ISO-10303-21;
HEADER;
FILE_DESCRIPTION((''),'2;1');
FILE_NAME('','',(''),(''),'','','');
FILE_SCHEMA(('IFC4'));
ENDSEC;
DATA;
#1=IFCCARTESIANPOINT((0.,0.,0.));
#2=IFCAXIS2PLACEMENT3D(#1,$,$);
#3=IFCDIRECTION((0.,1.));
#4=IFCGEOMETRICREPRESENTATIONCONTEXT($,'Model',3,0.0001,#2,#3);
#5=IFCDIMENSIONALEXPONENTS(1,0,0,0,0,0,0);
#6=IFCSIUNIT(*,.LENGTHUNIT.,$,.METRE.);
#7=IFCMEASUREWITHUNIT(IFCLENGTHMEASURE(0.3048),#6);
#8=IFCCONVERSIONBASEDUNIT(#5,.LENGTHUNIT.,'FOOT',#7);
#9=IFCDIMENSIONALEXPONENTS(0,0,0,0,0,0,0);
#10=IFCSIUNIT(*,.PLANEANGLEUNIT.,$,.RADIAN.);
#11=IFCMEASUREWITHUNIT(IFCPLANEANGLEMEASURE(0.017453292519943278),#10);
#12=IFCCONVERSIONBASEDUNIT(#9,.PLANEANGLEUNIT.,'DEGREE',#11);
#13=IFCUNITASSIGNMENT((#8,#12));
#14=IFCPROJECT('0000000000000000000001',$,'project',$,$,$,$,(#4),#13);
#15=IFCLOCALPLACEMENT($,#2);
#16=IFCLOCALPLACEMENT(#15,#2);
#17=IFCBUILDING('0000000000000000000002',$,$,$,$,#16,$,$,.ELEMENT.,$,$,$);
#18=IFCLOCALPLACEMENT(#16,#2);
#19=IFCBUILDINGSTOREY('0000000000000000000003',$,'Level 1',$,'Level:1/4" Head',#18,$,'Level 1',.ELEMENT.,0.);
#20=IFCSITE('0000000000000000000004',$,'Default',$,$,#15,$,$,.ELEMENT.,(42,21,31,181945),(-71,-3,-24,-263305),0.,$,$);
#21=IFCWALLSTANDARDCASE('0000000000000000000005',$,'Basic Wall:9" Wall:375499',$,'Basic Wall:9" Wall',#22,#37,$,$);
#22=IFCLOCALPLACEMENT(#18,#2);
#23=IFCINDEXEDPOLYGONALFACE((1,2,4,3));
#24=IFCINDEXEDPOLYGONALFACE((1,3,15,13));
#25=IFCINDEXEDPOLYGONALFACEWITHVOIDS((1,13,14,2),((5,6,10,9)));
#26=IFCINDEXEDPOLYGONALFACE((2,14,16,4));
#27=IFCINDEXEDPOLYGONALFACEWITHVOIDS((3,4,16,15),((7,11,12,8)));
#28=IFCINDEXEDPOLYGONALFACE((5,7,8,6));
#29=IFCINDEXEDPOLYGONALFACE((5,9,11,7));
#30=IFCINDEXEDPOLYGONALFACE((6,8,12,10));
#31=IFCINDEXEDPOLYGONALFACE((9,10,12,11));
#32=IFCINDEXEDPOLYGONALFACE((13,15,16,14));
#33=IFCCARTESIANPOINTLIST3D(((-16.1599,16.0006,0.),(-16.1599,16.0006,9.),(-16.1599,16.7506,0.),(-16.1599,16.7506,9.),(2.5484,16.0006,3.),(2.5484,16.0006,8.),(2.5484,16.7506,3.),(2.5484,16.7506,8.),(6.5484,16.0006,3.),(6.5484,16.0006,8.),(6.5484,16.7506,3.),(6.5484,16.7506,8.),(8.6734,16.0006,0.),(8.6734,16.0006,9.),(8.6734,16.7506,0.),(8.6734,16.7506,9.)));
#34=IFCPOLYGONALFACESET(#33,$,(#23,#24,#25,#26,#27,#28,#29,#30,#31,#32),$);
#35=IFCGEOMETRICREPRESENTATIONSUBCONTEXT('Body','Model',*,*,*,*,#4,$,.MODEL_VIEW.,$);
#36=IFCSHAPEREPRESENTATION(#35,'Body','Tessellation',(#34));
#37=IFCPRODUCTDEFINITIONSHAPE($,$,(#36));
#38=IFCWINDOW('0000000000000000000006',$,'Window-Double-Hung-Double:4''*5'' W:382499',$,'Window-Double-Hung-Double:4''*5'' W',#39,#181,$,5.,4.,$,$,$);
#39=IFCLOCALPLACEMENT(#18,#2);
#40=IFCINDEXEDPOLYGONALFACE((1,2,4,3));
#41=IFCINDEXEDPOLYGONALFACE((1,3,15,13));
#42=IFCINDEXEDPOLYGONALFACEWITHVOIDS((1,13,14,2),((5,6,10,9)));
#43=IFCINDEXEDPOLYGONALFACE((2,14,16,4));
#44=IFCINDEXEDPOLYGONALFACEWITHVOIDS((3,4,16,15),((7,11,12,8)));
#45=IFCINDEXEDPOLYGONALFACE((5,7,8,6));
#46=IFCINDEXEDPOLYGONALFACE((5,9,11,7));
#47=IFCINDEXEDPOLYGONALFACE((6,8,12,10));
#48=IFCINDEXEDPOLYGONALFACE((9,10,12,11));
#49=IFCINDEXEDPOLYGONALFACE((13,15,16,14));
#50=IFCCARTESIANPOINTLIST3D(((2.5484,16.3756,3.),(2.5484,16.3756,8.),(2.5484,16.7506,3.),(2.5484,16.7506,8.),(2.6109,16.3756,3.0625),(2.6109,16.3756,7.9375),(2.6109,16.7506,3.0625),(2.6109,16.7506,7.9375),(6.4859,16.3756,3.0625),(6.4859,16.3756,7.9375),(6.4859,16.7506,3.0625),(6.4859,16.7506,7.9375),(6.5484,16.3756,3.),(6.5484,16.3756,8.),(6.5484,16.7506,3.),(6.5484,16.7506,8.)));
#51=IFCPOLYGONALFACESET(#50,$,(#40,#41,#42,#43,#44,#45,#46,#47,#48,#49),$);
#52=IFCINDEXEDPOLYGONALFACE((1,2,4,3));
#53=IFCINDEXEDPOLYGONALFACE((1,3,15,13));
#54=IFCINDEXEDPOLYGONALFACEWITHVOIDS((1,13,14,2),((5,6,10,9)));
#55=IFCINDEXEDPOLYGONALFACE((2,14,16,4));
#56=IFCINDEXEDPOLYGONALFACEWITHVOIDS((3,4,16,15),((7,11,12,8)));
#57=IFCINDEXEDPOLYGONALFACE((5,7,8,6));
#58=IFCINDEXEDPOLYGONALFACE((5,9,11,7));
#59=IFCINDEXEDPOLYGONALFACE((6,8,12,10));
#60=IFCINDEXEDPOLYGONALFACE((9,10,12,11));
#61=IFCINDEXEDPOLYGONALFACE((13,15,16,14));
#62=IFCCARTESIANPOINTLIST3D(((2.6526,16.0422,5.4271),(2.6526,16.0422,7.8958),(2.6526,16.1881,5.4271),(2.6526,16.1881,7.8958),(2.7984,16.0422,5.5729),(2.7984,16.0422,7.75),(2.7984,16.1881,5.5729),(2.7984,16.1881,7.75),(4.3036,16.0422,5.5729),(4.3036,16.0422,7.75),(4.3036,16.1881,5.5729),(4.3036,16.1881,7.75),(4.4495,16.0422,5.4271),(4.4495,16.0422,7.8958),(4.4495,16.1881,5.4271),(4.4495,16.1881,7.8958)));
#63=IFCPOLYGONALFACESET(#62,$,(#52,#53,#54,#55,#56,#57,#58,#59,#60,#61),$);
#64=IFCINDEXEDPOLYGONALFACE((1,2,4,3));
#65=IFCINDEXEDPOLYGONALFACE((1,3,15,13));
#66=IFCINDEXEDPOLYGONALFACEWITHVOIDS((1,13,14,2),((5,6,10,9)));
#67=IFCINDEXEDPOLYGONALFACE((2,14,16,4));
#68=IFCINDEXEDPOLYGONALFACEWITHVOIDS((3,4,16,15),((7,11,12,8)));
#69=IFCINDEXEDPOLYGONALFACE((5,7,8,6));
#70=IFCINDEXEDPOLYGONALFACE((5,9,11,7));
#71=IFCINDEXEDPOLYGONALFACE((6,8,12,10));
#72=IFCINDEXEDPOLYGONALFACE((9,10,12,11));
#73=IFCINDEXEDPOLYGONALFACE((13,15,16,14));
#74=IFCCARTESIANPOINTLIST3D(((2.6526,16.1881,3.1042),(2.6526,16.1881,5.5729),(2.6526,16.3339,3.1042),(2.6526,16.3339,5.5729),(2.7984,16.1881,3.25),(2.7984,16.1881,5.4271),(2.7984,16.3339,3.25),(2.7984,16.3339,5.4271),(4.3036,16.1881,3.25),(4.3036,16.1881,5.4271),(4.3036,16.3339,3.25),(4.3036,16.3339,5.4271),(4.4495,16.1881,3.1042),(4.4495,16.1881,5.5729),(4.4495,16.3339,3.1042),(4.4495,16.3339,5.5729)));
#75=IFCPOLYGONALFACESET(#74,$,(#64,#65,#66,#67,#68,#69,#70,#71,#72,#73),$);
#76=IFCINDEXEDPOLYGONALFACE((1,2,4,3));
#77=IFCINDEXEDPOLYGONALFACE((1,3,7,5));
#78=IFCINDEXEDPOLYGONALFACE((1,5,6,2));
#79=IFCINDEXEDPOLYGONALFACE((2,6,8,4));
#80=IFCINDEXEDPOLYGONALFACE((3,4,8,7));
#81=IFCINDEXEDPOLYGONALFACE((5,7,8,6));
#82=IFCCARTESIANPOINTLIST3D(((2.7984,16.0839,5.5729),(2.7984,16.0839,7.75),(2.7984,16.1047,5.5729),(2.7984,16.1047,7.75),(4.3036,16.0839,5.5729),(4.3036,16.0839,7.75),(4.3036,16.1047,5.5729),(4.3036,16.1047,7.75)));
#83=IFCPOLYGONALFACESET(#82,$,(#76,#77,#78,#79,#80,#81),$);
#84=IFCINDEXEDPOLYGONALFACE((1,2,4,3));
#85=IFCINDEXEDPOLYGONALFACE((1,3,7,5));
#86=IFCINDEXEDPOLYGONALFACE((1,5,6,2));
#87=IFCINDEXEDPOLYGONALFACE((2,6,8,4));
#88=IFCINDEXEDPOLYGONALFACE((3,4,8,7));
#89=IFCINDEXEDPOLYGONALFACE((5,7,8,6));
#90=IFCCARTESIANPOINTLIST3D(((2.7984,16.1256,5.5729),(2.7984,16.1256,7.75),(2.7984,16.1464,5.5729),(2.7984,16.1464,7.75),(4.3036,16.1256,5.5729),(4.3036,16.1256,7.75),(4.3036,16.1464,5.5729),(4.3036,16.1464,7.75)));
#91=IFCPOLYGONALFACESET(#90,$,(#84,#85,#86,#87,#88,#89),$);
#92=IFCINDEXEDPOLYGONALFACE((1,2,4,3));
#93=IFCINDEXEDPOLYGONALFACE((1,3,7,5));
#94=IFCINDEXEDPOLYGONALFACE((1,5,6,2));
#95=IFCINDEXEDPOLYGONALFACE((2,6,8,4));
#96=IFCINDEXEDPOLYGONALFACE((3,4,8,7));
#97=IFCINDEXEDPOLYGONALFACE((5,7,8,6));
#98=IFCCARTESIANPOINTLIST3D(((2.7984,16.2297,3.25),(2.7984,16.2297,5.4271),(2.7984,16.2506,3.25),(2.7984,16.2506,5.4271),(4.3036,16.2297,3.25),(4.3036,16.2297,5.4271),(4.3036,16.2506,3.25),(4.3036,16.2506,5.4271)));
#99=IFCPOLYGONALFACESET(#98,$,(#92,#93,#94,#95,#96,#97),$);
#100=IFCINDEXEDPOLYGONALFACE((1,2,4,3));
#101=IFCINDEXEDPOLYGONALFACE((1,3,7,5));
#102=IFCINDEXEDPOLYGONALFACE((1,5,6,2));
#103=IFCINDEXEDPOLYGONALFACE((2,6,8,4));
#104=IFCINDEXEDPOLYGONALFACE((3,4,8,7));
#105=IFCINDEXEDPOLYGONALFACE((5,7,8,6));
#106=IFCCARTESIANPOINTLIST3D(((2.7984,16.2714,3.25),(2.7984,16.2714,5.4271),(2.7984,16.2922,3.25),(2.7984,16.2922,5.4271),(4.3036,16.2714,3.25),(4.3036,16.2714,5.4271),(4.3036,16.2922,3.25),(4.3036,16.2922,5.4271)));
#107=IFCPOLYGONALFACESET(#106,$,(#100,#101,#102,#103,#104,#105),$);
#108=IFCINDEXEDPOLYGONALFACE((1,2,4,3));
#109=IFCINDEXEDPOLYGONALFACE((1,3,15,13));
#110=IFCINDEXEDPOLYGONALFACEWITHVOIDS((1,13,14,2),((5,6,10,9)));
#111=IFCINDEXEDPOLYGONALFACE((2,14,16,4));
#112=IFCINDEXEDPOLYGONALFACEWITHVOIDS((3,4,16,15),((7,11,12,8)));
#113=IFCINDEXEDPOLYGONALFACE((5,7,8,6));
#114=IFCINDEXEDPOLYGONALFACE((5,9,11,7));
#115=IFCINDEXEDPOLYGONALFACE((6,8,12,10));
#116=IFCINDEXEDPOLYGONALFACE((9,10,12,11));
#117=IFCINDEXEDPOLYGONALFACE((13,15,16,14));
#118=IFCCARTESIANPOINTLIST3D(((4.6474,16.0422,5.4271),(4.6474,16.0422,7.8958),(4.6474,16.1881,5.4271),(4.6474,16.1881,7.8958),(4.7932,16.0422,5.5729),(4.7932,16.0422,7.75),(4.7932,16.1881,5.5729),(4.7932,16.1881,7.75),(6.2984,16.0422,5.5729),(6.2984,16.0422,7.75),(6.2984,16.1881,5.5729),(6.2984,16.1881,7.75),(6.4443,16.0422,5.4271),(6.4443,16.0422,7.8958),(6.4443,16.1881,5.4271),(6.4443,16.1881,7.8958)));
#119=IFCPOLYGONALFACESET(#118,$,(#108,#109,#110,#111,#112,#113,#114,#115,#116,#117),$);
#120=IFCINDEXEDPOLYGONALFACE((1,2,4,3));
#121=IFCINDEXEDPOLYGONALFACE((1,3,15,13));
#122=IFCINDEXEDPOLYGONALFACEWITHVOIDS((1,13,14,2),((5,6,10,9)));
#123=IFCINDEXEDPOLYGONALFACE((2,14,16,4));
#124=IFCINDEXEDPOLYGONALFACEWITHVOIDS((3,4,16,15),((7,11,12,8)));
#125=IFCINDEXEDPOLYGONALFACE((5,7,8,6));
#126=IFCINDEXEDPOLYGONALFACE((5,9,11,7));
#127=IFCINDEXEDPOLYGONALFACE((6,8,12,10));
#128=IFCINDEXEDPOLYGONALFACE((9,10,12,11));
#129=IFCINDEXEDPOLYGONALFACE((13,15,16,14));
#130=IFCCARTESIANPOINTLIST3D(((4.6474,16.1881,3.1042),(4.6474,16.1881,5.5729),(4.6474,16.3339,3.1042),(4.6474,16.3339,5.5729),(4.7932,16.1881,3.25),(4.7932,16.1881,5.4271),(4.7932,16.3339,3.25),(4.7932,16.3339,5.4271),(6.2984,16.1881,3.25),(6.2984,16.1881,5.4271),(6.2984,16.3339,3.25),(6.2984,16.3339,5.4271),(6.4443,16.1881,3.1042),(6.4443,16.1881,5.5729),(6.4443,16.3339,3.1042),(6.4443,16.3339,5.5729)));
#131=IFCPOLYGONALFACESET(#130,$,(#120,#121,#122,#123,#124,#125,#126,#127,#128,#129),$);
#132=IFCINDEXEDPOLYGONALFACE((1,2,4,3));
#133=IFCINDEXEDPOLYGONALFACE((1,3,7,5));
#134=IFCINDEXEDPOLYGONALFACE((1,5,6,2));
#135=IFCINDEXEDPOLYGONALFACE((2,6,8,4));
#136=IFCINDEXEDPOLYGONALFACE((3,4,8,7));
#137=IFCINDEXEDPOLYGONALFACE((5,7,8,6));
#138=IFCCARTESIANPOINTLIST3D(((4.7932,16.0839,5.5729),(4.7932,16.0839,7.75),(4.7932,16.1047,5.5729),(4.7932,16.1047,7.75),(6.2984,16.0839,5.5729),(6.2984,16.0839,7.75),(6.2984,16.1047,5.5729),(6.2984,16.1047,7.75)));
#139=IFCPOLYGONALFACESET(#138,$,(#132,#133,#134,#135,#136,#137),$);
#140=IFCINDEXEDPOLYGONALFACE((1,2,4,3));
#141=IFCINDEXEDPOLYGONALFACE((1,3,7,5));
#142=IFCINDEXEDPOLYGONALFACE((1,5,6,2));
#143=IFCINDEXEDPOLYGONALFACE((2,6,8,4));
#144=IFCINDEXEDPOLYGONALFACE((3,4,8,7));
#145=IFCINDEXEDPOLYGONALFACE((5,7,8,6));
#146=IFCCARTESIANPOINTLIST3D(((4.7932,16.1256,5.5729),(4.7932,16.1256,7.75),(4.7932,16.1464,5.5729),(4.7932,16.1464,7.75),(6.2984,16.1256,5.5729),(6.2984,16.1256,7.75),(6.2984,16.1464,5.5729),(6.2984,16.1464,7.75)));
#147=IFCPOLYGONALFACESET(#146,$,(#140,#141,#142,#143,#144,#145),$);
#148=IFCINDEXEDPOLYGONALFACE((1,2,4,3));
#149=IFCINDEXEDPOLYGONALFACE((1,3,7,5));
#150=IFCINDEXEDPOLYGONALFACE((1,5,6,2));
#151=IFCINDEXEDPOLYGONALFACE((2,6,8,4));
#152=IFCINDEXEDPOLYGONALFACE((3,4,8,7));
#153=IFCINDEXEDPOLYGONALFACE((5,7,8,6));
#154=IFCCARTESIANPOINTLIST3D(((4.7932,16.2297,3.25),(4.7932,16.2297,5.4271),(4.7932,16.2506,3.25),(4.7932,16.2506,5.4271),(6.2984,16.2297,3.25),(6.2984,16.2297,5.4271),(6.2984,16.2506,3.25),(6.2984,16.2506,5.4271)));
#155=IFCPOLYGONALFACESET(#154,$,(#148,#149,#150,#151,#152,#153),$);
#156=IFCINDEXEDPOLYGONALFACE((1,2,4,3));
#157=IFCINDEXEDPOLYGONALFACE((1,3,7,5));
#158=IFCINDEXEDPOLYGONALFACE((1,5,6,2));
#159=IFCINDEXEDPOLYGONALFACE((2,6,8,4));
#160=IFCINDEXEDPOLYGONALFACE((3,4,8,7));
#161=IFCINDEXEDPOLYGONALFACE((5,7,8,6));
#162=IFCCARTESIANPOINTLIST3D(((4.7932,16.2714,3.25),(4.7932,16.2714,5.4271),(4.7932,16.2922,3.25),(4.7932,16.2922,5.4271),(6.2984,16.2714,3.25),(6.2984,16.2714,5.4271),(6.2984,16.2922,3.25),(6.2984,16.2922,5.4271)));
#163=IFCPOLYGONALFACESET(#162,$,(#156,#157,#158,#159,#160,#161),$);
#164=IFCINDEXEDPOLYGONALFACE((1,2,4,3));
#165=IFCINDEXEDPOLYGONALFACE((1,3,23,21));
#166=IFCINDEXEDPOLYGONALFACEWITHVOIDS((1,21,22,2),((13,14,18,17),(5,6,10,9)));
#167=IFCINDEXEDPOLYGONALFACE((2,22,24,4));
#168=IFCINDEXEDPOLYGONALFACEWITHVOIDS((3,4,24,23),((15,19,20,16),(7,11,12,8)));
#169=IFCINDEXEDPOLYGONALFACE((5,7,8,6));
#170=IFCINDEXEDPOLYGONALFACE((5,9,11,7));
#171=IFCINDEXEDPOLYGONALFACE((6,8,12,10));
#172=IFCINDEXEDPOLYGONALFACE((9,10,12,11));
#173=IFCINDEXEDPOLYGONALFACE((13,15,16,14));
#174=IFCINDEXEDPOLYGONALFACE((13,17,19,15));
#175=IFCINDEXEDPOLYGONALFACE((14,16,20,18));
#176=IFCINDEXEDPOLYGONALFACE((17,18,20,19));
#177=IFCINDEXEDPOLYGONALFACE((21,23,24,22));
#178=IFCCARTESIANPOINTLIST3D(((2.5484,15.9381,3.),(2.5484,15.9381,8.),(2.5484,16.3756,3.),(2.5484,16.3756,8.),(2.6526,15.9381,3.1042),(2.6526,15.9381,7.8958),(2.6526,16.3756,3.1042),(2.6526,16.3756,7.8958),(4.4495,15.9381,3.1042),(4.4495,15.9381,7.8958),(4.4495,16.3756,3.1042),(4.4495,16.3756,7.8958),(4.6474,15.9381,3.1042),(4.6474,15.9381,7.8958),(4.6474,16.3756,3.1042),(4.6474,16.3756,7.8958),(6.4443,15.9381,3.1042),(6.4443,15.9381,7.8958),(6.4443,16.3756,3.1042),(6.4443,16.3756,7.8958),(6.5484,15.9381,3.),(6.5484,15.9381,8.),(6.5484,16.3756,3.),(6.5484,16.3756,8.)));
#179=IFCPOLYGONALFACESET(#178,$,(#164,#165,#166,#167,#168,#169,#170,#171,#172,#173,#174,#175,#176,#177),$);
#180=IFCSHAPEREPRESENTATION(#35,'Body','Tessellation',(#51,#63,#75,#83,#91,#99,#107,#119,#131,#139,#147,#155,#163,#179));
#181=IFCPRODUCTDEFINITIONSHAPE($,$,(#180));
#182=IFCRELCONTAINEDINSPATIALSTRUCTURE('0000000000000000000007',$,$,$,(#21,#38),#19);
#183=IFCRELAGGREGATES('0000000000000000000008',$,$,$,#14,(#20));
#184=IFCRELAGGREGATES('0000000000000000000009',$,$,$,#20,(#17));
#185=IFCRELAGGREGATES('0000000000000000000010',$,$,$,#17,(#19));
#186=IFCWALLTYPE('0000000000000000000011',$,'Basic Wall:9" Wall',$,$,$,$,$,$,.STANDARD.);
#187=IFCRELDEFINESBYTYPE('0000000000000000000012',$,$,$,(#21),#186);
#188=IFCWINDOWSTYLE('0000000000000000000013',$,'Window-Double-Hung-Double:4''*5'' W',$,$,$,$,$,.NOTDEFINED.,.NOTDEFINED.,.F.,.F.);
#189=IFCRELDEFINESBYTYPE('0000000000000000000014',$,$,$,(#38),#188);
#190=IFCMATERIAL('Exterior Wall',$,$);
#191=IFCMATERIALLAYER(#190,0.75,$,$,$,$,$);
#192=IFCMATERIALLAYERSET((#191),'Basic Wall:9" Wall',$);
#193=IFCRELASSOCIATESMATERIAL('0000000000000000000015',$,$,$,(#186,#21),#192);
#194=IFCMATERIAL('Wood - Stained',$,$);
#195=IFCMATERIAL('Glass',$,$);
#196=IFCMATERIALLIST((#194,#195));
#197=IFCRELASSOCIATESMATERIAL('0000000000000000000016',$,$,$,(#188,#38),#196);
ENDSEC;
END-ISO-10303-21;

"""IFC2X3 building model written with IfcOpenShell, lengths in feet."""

from ifc_helpers import new_model, entity, si_unit, converted_unit, direction, frame, frame_2d, origin, origin_2d_with_axis, place, context, subcontext, project, spatial, polyline, rectangle, outline, extrude, clip, bounded_halfspace, source, transform, mapped, material, material_list, layer, layer_set, layer_usage, type_object, type_shapes, element, fill, save


model = new_model("IFC2X3")

# Units and contexts
model_context = context("Model", 3, precision=0.0001, world=origin(), true_north=direction((0.0, 1.0)))
body_context = subcontext(model_context, "Body", "Model", "MODEL_VIEW")
ifc_project = project(units=[converted_unit("LENGTHUNIT", "FOOT", entity("IfcLengthMeasure", 0.3048), si_unit("LENGTHUNIT", "METRE"), dimensions=[1, 0, 0, 0, 0, 0, 0]), converted_unit("PLANEANGLEUNIT", "DEGREE", entity("IfcPlaneAngleMeasure", 0.017453292519943278), si_unit("PLANEANGLEUNIT", "RADIAN"), dimensions=[0, 0, 0, 0, 0, 0, 0])], contexts=[model_context])

# Site, building, storey
site_placement = place(None, origin())
site = spatial("IfcSite", under=ifc_project, at=site_placement, Name="Default", CompositionType="ELEMENT", RefLatitude=(42, 21, 31, 181945), RefLongitude=(-71, -3, -24, -263305), RefElevation=0.0)
building_placement = place(site_placement, origin())
building = spatial("IfcBuilding", under=site, at=building_placement, CompositionType="ELEMENT")
storey_placement = place(building_placement, origin())
storey = spatial("IfcBuildingStorey", under=building, at=storey_placement, Name="Level 1", ObjectType="Level:1/4\" Head", LongName="Level 1", CompositionType="ELEMENT", Elevation=0.0)

# Shared definitions
ifc_material_1 = material(Name="Exterior Wall")
ifc_layer = layer(ifc_material_1, 0.75)
ifc_layer_set = layer_set([ifc_layer], Name="Basic Wall:9\" Wall")
ifc_layer_usage = layer_usage(ifc_layer_set, "AXIS2", "NEGATIVE", 0.375)
wall_type = type_object("IfcWallType", Name="Basic Wall:9\" Wall", PredefinedType="STANDARD", material=ifc_layer_set)

# Wall, opening, window
wall_1_placement = place(storey_placement, frame((-16.1599, 16.3756, 0.0)))
wall_1 = element("IfcWallStandardCase", 1, at=wall_1_placement, inside=storey, type_object=wall_type, material=ifc_layer_usage, Name="Basic Wall:9\" Wall:375499", ObjectType="Basic Wall:9\" Wall", context=body_context, shape_type="Clipping", body=[
    clip(extrude(rectangle(XDim=24.8333, YDim=0.75, at=frame_2d((12.4167, 0.0), x_axis=(-1.0, 0.0))), origin(), (0.0, 0.0, 1.0), 9.0), bounded_halfspace(frame((0.0, -0.375, 9.0), z_axis=(0.0, 0.0, -1.0), x_axis=(0.0, -1.0, 0.0)), True, frame((0.0, -0.375, 9.0)), polyline([(0.0, 0.0), (8.875, 0.0), (9.625, 0.0), (16.625, 0.0), (17.375, 0.0), (24.0833, 0.0), (24.8333, 0.0), (24.8333, 0.75), (0.0, 0.75), (0.0, 0.0)]))),
])
opening_1_placement = place(wall_1_placement, frame((22.7083, 0.375, 3.0)))
opening_1 = element("IfcOpeningElement", 2, at=opening_1_placement, cuts=wall_1, ObjectType="Opening", context=body_context, shape_type="SweptSolid", body=[
    extrude(rectangle(XDim=5.0, YDim=4.0, at=frame_2d((2.5, 2.0), x_axis=(-1.0, 0.0))), frame((0.0, 0.0, 0.0), z_axis=(0.0, -1.0, 0.0), x_axis=(0.0, 0.0, 1.0)), (0.0, 0.0, 1.0), 0.75),
])
ifc_material_2 = material(Name="Wood - Stained")
ifc_material_3 = material(Name="Glass")
ifc_material_list_1 = material_list([ifc_material_2, ifc_material_3])
window_style = type_object("IfcWindowStyle", Name="Window-Double-Hung-Double:4'*5' W", ConstructionType="NOTDEFINED", OperationType="NOTDEFINED", ParameterTakesPrecedence=False, Sizeable=False, material=ifc_material_list_1)
shared_shape_1 = source(origin(), body_context, "Body", "SweptSolid", [
    extrude(outline(polyline([(-2.5, -2.0), (2.5, -2.0), (2.5, 2.0), (-2.5, 2.0), (-2.5, -2.0)]), holes=[polyline([(-2.4375, -1.9375), (-2.4375, 1.9375), (2.4375, 1.9375), (2.4375, -1.9375), (-2.4375, -1.9375)])]), frame((2.0, 0.0, 2.5), z_axis=(0.0, 1.0, 0.0), x_axis=(0.0, 0.0, -1.0)), (0.0, 0.0, 1.0), 0.375),
    extrude(outline(polyline([(-0.8984, -1.2344), (0.8984, -1.2344), (0.8984, 1.2344), (-0.8984, 1.2344), (-0.8984, -1.2344)]), holes=[polyline([(0.7526, -1.0885), (-0.7526, -1.0885), (-0.7526, 1.0885), (0.7526, 1.0885), (0.7526, -1.0885)])]), frame((2.9974, 0.5625, 3.6615), z_axis=(0.0, 1.0, 0.0), x_axis=(1.0, 0.0, 0.0)), (0.0, 0.0, 1.0), 0.1458),
    extrude(outline(polyline([(-0.8984, -1.2344), (0.8984, -1.2344), (0.8984, 1.2344), (-0.8984, 1.2344), (-0.8984, -1.2344)]), holes=[polyline([(0.7526, -1.0885), (-0.7526, -1.0885), (-0.7526, 1.0885), (0.7526, 1.0885), (0.7526, -1.0885)])]), frame((2.9974, 0.4167, 1.3385), z_axis=(0.0, 1.0, 0.0), x_axis=(1.0, 0.0, 0.0)), (0.0, 0.0, 1.0), 0.1458),
    extrude(rectangle(XDim=1.5052, YDim=0.0208, at=frame_2d((0.0, 0.0), x_axis=(1.0, 0.0))), frame((2.9974, 0.6563, 2.5729), z_axis=(0.0, 0.0, 1.0), x_axis=(-1.0, 0.0, 0.0)), (0.0, 0.0, 1.0), 2.1771),
    extrude(rectangle(XDim=0.0208, YDim=1.5052, at=frame_2d((0.0, 0.0), x_axis=(1.0, 0.0))), frame((2.9974, 0.6146, 2.5729), z_axis=(0.0, 0.0, 1.0), x_axis=(0.0, -1.0, 0.0)), (0.0, 0.0, 1.0), 2.1771),
    extrude(rectangle(XDim=1.5052, YDim=0.0208, at=frame_2d((0.0, 0.0), x_axis=(1.0, 0.0))), frame((2.9974, 0.5104, 0.25), z_axis=(0.0, 0.0, 1.0), x_axis=(-1.0, 0.0, 0.0)), (0.0, 0.0, 1.0), 2.1771),
    extrude(rectangle(XDim=0.0208, YDim=1.5052, at=origin_2d_with_axis()), frame((2.9974, 0.4687, 0.25), z_axis=(0.0, 0.0, 1.0), x_axis=(0.0, -1.0, 0.0)), (0.0, 0.0, 1.0), 2.1771),
    extrude(outline(polyline([(-0.8984, -1.2344), (0.8984, -1.2344), (0.8984, 1.2344), (-0.8984, 1.2344), (-0.8984, -1.2344)]), holes=[polyline([(0.7526, -1.0885), (-0.7526, -1.0885), (-0.7526, 1.0885), (0.7526, 1.0885), (0.7526, -1.0885)])]), frame((1.0026, 0.5625, 3.6615), z_axis=(0.0, 1.0, 0.0), x_axis=(1.0, 0.0, 0.0)), (0.0, 0.0, 1.0), 0.1458),
    extrude(outline(polyline([(-0.8984, -1.2344), (0.8984, -1.2344), (0.8984, 1.2344), (-0.8984, 1.2344), (-0.8984, -1.2344)]), holes=[polyline([(0.7526, -1.0885), (-0.7526, -1.0885), (-0.7526, 1.0885), (0.7526, 1.0885), (0.7526, -1.0885)])]), frame((1.0026, 0.4167, 1.3385), z_axis=(0.0, 1.0, 0.0), x_axis=(1.0, 0.0, 0.0)), (0.0, 0.0, 1.0), 0.1458),
    extrude(rectangle(XDim=0.0208, YDim=1.5052, at=origin_2d_with_axis()), frame((1.0026, 0.6563, 2.5729), z_axis=(0.0, 0.0, 1.0), x_axis=(0.0, -1.0, 0.0)), (0.0, 0.0, 1.0), 2.1771),
    extrude(rectangle(XDim=1.5052, YDim=0.0208, at=frame_2d((0.0, 0.0), x_axis=(1.0, 0.0))), frame((1.0026, 0.6146, 2.5729), z_axis=(0.0, 0.0, 1.0), x_axis=(-1.0, 0.0, 0.0)), (0.0, 0.0, 1.0), 2.1771),
    extrude(rectangle(XDim=0.0208, YDim=1.5052, at=frame_2d((0.0, 0.0), x_axis=(1.0, 0.0))), frame((1.0026, 0.5104, 0.25), z_axis=(0.0, 0.0, 1.0), x_axis=(0.0, -1.0, 0.0)), (0.0, 0.0, 1.0), 2.1771),
    extrude(rectangle(XDim=1.5052, YDim=0.0208, at=frame_2d((0.0, 0.0), x_axis=(1.0, 0.0))), frame((1.0026, 0.4687, 0.25), z_axis=(0.0, 0.0, 1.0), x_axis=(-1.0, 0.0, 0.0)), (0.0, 0.0, 1.0), 2.1771),
    extrude(outline(polyline([(-2.5, -2.0), (2.5, -2.0), (2.5, 2.0), (-2.5, 2.0), (-2.5, -2.0)]), holes=[polyline([(2.3958, 1.8958), (2.3958, 0.099), (-2.3958, 0.099), (-2.3958, 1.8958), (2.3958, 1.8958)]), polyline([(2.3958, -1.8958), (-2.3958, -1.8958), (-2.3958, -0.099), (2.3958, -0.099), (2.3958, -1.8958)])]), frame((2.0, 0.375, 2.5), z_axis=(0.0, 1.0, 0.0), x_axis=(0.0, 0.0, -1.0)), (0.0, 0.0, 1.0), 0.4375),
])
type_shapes(window_style, [shared_shape_1])
window_placement = place(opening_1_placement, frame((0.0, 0.0, 0.0), z_axis=(0.0, 0.0, 1.0), x_axis=(-1.0, 0.0, 0.0)))
window = element("IfcWindow", 3, at=window_placement, inside=storey, type_object=window_style, material=ifc_material_list_1, Name="Window-Double-Hung-Double:4'*5' W:382499", ObjectType="Window-Double-Hung-Double:4'*5' W", OverallHeight=5.0, OverallWidth=4.0, context=body_context, shape_type="MappedRepresentation", body=[
    mapped(shared_shape_1, transform((0.0, 0.0, 0.0), scale=1.0)),
])
fill(opening_1, window)

save(model, "model.ifc")
